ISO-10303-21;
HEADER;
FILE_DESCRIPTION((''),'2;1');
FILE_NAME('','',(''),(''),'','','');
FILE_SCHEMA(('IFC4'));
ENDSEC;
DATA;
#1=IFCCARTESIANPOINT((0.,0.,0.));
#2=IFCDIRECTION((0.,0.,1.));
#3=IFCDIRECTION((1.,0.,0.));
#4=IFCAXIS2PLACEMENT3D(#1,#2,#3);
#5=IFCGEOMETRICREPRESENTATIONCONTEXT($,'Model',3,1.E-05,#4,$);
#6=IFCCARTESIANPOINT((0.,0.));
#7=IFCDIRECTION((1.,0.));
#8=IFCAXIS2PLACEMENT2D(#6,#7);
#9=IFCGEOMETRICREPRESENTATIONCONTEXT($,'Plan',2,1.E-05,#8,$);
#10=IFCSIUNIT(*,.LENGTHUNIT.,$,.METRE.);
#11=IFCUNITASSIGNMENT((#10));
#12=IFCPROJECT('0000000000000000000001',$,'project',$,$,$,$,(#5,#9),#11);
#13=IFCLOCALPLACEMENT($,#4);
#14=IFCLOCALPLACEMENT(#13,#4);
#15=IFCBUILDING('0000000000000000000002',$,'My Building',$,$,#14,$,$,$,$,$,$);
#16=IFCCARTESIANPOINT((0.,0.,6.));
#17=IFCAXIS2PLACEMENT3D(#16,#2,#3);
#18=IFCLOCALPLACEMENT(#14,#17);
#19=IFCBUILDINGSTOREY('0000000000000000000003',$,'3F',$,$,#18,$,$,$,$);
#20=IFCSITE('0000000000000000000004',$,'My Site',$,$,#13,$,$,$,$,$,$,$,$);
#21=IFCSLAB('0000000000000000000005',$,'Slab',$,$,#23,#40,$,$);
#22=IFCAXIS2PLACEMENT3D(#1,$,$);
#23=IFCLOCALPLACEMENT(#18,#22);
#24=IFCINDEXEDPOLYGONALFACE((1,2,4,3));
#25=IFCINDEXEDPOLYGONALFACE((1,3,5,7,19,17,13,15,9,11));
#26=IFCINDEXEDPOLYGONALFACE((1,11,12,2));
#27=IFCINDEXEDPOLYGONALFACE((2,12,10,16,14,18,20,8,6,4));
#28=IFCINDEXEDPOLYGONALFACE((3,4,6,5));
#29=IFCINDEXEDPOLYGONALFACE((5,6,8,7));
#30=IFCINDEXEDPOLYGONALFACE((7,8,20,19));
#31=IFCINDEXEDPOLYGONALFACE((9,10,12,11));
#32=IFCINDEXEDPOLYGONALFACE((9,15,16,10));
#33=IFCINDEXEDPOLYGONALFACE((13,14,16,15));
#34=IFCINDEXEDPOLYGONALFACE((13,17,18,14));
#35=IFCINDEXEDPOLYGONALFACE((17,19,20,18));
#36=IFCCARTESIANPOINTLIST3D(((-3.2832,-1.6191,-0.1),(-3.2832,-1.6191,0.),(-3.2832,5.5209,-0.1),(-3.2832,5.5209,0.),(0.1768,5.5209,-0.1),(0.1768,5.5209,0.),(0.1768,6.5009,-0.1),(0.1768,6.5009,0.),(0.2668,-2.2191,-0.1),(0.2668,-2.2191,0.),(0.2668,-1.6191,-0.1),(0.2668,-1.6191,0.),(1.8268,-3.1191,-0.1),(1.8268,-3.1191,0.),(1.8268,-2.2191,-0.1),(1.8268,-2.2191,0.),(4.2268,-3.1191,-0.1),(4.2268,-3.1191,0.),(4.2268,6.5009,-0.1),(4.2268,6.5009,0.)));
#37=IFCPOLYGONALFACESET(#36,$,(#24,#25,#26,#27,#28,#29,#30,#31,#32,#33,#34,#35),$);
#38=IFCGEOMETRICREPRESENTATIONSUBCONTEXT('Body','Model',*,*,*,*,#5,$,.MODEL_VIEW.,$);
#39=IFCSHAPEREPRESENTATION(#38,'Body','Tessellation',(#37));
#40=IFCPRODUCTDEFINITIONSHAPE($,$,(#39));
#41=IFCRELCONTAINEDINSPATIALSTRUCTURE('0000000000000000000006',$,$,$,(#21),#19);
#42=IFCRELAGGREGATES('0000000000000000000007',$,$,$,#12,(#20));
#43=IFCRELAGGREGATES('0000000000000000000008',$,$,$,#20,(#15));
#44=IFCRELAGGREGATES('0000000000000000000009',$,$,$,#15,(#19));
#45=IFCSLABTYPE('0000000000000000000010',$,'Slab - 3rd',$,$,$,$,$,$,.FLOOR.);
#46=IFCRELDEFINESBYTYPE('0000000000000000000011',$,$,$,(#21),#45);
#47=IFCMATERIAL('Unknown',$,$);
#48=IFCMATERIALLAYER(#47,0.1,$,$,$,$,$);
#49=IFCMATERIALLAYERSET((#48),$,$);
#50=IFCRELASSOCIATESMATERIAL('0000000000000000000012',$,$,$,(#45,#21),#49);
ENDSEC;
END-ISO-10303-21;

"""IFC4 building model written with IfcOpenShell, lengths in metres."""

from ifc_helpers import new_model, si_unit, frame, origin_with_axes, origin_2d_with_axis, place, context, subcontext, project, spatial, indexed_curve, outline, extrude, material, layer, layer_set, layer_usage, type_object, element, save


model = new_model("IFC4")

# Units and contexts
model_context = context("Model", 3, precision=1e-05, world=origin_with_axes())
plan_context = context("Plan", 2, precision=1e-05, world=origin_2d_with_axis())
body_context = subcontext(model_context, "Body", "Model", "MODEL_VIEW")
ifc_project = project(units=[si_unit("LENGTHUNIT", "METRE")], contexts=[model_context, plan_context])

# Site, building, storey
site_placement = place(None, origin_with_axes())
site = spatial("IfcSite", under=ifc_project, at=site_placement, Name="My Site")
building_placement = place(site_placement, origin_with_axes())
building = spatial("IfcBuilding", under=site, at=building_placement, Name="My Building")
storey_placement = place(building_placement, frame((0.0, 0.0, 6.0), z_axis=(0.0, 0.0, 1.0), x_axis=(1.0, 0.0, 0.0)))
storey = spatial("IfcBuildingStorey", under=building, at=storey_placement, Name="3F")

# Slab
ifc_material = material(Name="Unknown")
ifc_layer = layer(ifc_material, 0.1)
ifc_layer_set = layer_set([ifc_layer])
ifc_layer_usage = layer_usage(ifc_layer_set, "AXIS3", "POSITIVE", -0.1)
slab_type = type_object("IfcSlabType", Name="Slab - 3rd", PredefinedType="FLOOR", material=ifc_layer_set)
slab_placement = place(storey_placement, frame((4.2268, 6.5009, 0.0), z_axis=(0.0, 0.0, 1.0), x_axis=(1.0, 0.0, 0.0)))
element("IfcSlab", 1, at=slab_placement, inside=storey, type_object=slab_type, material=ifc_layer_usage, Name="Slab", context=body_context, shape_type="SweptSolid", body=[
    extrude(outline(indexed_curve([(0.0, 0.0), (-4.05, 0.0), (-4.05, -0.98), (-7.51, -0.98), (-7.51, -8.12), (-3.96, -8.12), (-3.96, -8.72), (-2.4, -8.72), (-2.4, -9.62), (0.0, -9.62), (0.0, 0.0)])), frame((0.0, 0.0, -0.1), z_axis=(0.0, 0.0, 1.0), x_axis=(1.0, 0.0, 0.0)), (0.0, 0.0, 1.0), 0.1),
])

save(model, "model.ifc")
